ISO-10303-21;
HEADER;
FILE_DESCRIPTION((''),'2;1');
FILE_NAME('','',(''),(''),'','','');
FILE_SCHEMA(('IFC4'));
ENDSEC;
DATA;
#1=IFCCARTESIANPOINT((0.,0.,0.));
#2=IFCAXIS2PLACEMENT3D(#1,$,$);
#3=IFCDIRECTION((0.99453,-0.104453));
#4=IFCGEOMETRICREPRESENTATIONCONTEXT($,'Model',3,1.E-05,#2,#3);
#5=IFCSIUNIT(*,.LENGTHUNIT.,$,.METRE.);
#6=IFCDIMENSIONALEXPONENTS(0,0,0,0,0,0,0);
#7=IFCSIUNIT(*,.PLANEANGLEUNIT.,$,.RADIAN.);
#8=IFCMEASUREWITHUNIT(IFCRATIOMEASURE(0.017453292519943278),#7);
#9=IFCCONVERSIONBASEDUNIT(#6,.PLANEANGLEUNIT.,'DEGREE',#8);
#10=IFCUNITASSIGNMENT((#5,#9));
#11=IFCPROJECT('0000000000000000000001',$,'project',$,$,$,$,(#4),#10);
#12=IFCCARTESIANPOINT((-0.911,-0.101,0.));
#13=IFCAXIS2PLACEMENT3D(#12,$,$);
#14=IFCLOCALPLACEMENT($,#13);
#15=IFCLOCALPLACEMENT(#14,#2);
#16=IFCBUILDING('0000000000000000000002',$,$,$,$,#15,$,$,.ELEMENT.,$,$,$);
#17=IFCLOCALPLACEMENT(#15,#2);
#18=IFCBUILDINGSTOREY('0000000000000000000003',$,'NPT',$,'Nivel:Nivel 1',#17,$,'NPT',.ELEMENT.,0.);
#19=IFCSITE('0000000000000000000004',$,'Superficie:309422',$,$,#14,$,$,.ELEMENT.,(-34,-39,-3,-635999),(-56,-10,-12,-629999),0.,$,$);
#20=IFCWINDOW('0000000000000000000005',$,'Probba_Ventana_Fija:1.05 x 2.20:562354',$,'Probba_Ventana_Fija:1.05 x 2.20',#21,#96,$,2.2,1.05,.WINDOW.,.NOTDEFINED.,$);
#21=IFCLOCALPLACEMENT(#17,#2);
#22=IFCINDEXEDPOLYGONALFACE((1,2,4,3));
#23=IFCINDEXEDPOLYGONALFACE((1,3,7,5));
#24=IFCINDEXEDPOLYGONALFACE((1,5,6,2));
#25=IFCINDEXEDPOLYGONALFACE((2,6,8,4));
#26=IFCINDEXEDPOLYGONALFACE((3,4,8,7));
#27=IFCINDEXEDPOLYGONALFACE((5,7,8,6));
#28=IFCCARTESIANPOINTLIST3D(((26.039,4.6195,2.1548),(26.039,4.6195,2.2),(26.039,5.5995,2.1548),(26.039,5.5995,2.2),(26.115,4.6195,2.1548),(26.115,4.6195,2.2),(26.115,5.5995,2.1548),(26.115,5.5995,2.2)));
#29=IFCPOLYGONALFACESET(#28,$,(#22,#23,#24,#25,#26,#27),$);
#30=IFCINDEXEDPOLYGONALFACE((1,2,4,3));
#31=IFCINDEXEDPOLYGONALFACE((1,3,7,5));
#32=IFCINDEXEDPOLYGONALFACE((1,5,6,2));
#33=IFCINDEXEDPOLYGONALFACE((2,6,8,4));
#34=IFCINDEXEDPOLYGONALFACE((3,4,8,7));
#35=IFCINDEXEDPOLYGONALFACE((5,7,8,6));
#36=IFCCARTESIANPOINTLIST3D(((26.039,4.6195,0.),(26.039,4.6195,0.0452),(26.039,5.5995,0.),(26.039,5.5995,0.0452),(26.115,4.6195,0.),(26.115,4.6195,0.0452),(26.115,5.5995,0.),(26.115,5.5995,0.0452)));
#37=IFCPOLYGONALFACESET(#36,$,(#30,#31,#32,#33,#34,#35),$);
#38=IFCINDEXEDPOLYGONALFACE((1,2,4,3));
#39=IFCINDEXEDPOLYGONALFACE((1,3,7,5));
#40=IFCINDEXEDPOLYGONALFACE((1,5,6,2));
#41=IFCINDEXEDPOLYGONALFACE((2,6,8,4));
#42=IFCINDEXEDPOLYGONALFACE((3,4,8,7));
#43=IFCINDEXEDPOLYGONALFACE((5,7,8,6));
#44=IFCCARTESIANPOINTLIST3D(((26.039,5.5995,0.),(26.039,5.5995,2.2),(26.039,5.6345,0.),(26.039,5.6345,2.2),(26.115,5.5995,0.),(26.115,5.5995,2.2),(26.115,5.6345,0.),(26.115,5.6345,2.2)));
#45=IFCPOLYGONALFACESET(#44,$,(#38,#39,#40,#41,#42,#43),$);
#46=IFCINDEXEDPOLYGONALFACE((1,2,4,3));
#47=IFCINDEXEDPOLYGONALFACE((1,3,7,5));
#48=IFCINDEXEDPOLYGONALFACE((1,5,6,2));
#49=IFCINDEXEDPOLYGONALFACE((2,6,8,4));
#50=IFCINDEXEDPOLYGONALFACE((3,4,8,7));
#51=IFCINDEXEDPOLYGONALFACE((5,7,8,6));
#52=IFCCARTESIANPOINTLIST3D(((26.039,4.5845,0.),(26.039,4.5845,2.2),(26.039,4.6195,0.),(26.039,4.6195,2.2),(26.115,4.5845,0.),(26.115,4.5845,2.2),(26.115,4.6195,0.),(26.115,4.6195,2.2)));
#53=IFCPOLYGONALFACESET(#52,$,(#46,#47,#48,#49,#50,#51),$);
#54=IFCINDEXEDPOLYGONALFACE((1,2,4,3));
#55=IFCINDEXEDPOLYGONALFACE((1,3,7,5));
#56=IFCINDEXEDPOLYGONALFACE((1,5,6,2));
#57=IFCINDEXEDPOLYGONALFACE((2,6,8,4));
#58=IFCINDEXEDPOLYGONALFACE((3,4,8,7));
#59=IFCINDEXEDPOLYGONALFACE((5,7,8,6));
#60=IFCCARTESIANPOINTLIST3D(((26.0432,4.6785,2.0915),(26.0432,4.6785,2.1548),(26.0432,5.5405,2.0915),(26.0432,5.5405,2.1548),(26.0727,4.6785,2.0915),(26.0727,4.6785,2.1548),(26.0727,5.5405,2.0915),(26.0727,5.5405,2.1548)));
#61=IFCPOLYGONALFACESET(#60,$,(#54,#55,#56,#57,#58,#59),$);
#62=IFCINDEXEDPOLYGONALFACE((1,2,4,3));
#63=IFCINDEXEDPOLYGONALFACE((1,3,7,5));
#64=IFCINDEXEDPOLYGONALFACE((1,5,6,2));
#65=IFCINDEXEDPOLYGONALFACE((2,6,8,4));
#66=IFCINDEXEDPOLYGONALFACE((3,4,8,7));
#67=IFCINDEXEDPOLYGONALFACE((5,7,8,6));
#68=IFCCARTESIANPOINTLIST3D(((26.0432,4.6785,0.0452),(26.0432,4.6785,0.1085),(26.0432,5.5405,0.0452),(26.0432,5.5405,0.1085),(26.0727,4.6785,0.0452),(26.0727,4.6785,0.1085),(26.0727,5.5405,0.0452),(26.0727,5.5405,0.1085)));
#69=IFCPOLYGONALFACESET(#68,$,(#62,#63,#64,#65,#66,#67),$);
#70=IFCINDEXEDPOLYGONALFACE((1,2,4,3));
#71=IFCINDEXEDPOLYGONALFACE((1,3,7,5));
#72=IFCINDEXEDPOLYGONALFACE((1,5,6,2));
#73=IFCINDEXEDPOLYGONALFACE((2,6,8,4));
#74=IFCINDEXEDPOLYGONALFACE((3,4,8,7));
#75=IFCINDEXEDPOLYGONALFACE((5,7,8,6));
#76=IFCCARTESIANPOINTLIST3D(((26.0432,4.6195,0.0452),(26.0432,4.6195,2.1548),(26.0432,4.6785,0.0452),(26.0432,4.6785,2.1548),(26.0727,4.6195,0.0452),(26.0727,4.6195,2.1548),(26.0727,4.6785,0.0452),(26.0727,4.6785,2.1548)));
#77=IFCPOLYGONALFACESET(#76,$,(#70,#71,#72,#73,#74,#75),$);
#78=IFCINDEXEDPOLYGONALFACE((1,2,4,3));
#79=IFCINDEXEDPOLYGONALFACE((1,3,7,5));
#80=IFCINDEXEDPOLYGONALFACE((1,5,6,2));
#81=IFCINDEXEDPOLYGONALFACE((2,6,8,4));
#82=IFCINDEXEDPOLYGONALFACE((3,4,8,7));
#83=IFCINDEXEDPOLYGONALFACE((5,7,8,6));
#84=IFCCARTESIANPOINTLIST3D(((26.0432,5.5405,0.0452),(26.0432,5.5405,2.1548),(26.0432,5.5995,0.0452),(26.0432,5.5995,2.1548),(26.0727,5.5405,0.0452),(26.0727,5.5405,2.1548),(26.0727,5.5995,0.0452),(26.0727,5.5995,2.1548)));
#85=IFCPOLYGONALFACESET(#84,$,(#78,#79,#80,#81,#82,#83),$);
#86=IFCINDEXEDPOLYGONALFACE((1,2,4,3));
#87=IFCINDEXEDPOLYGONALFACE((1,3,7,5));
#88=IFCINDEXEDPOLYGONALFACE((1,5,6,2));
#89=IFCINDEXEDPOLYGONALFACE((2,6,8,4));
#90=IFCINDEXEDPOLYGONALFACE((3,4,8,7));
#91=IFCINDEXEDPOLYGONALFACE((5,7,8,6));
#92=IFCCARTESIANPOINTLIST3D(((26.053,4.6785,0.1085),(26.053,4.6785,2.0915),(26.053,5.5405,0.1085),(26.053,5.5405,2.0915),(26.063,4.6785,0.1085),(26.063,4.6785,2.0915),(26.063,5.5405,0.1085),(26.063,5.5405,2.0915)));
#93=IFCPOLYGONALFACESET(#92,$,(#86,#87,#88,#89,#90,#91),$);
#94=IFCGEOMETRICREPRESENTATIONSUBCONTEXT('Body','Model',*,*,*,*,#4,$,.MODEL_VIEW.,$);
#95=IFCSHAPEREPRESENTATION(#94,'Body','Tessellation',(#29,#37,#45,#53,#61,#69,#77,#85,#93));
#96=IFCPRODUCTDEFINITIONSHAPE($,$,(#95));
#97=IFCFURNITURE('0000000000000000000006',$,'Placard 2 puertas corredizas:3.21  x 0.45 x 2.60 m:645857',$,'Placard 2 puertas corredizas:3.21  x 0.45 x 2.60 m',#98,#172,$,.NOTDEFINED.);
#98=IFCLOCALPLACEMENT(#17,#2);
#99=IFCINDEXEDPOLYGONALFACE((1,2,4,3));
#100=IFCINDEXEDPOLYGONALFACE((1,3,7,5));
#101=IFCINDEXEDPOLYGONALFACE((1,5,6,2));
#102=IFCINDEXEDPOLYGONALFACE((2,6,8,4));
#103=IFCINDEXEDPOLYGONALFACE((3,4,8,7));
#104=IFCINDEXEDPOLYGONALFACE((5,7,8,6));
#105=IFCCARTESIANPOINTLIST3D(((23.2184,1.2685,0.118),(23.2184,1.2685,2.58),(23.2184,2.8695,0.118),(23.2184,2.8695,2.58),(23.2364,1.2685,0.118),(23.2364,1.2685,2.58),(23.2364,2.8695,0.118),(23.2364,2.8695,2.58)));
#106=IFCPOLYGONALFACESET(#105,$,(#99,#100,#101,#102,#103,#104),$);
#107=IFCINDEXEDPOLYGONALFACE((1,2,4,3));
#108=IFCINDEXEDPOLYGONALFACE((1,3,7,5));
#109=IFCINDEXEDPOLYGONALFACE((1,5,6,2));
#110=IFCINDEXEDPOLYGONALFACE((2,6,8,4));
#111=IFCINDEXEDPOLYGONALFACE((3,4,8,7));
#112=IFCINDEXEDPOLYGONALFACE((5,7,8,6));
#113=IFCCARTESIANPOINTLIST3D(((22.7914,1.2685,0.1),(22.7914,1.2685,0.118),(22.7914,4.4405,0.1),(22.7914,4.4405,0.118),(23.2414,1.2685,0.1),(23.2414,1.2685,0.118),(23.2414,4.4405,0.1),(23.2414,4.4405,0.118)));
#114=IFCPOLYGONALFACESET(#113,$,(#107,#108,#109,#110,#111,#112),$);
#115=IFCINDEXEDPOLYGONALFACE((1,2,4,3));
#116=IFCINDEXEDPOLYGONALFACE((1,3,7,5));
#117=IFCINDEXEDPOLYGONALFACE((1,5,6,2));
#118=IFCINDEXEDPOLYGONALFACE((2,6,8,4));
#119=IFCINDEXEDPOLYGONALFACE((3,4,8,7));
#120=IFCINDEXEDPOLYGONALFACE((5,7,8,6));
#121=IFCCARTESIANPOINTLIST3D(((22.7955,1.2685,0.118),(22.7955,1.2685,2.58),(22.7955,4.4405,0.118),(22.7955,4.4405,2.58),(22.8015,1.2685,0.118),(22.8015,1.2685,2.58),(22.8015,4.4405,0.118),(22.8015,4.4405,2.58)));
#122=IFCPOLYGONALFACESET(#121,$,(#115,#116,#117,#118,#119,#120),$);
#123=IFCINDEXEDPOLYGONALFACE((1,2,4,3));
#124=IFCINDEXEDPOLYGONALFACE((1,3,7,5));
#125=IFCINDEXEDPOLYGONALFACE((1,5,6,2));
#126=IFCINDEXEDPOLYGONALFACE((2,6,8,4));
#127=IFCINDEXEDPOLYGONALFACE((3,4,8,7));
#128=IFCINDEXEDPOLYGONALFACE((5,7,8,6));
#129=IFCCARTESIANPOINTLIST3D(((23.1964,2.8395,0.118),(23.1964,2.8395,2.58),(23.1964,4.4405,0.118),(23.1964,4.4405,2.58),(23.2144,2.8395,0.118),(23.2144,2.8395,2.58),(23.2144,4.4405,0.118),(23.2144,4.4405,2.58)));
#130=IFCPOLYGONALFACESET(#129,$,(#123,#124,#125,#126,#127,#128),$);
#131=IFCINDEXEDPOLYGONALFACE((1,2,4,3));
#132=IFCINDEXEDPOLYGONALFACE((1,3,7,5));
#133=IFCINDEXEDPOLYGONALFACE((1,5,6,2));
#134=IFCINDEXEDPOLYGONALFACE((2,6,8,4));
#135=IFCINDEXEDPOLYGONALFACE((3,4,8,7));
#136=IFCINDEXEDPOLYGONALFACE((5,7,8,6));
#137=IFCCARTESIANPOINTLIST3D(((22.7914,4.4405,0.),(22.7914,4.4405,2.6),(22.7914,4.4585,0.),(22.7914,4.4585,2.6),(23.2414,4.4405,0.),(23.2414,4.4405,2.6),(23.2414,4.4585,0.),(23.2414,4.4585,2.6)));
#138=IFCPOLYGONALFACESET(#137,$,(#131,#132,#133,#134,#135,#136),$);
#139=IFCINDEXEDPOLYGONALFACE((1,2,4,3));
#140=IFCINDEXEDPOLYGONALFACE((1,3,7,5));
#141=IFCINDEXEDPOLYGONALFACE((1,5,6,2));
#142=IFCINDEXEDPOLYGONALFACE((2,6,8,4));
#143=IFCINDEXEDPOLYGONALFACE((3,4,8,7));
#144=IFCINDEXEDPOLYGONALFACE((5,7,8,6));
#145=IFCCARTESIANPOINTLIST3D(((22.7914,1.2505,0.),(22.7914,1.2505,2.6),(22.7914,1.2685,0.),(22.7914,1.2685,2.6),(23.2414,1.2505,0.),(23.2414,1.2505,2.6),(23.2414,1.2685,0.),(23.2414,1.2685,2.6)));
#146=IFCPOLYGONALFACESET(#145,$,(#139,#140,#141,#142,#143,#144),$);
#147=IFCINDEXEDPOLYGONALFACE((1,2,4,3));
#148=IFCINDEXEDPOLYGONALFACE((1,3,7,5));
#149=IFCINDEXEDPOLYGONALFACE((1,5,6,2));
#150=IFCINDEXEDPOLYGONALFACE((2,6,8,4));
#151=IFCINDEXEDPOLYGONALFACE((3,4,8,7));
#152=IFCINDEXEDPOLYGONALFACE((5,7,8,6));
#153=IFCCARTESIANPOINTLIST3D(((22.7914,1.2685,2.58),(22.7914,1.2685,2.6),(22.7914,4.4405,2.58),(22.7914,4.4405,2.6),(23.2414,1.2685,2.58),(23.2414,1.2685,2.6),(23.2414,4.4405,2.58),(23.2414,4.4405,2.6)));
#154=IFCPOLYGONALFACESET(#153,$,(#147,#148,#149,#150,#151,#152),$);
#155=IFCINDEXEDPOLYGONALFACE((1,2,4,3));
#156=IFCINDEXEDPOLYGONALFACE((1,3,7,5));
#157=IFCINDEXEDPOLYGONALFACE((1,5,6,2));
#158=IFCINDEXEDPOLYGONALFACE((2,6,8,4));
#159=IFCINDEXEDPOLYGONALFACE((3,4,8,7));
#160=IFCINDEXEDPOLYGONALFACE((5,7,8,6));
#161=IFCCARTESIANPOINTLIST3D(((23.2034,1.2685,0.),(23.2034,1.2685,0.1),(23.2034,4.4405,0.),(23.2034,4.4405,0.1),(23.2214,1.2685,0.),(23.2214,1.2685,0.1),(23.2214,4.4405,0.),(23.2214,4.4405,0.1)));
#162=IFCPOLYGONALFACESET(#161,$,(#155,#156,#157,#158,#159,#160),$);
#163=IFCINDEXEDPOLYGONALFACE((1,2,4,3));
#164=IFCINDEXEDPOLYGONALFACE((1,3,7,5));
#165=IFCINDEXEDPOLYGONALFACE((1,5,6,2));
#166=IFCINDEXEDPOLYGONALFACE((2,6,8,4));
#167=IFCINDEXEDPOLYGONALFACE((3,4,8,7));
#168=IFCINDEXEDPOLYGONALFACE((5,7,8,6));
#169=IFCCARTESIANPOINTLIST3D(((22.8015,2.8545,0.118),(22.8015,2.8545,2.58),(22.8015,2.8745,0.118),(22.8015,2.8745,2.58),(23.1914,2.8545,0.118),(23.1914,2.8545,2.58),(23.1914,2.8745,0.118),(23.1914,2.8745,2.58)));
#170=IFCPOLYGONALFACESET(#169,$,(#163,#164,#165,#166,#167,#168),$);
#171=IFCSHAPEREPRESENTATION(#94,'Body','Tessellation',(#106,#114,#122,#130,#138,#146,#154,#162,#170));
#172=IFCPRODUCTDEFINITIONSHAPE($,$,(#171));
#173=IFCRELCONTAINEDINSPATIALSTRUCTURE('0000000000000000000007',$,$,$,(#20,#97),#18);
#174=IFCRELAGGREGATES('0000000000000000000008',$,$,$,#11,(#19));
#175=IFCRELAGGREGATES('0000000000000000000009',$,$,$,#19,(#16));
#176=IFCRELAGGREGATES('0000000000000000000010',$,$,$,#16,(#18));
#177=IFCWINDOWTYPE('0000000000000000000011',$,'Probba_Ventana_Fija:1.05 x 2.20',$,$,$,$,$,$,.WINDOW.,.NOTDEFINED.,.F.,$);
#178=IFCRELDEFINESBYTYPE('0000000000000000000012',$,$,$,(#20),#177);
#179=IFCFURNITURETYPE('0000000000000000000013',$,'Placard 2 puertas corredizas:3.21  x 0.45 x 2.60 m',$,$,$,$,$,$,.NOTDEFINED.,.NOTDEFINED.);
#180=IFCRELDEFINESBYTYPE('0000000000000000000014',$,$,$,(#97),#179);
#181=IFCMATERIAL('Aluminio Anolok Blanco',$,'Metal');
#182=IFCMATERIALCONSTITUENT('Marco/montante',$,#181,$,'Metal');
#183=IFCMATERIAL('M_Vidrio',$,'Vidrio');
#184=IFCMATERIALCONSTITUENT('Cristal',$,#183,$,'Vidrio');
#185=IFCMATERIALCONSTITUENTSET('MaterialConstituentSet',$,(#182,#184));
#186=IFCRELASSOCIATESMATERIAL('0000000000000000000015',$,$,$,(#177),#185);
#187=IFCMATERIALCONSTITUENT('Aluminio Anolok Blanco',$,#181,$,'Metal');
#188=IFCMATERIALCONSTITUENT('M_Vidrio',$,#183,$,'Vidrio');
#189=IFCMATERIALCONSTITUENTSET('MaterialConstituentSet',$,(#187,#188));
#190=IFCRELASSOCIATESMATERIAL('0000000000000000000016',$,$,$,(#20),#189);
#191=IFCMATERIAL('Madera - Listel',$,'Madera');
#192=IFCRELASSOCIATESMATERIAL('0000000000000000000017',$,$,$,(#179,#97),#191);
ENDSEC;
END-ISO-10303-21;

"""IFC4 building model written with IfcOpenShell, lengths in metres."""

from ifc_helpers import new_model, entity, si_unit, converted_unit, direction, frame, frame_2d, origin, origin_2d_with_axis, place, context, subcontext, project, spatial, rectangle, extrude, source, transform, mapped, material, constituent, constituent_set, type_object, type_shapes, element, save


model = new_model("IFC4")

# Units and contexts
model_context = context("Model", 3, precision=1e-05, world=origin(), true_north=direction((0.99453, -0.104453)))
body_context = subcontext(model_context, "Body", "Model", "MODEL_VIEW")
ifc_project = project(units=[si_unit("LENGTHUNIT", "METRE"), converted_unit("PLANEANGLEUNIT", "DEGREE", entity("IfcRatioMeasure", 0.017453292519943278), si_unit("PLANEANGLEUNIT", "RADIAN"), dimensions=[0, 0, 0, 0, 0, 0, 0])], contexts=[model_context])

# Site, building, storey
site_placement = place(None, frame((-0.911, -0.101, 0.0)))
site = spatial("IfcSite", under=ifc_project, at=site_placement, Name="Superficie:309422", CompositionType="ELEMENT", RefLatitude=(-34, -39, -3, -635999), RefLongitude=(-56, -10, -12, -629999), RefElevation=0.0)
building_placement = place(site_placement, origin())
building = spatial("IfcBuilding", under=site, at=building_placement, CompositionType="ELEMENT")
storey_placement = place(building_placement, origin())
storey = spatial("IfcBuildingStorey", under=building, at=storey_placement, Name="NPT", ObjectType="Nivel:Nivel 1", LongName="NPT", CompositionType="ELEMENT", Elevation=0.0)

# Window
ifc_material_1 = material(Name="Aluminio Anolok Blanco", Category="Metal")
ifc_constituent_1 = constituent(ifc_material_1, Name="Aluminio Anolok Blanco", Category="Metal")
ifc_material_2 = material(Name="M_Vidrio", Category="Vidrio")
ifc_constituent_2 = constituent(ifc_material_2, Name="M_Vidrio", Category="Vidrio")
ifc_constituent_set_1 = constituent_set(constituents=[ifc_constituent_1, ifc_constituent_2], Name="MaterialConstituentSet")
ifc_constituent_3 = constituent(ifc_material_1, Name="Marco/montante", Category="Metal")
ifc_constituent_4 = constituent(ifc_material_2, Name="Cristal", Category="Vidrio")
ifc_constituent_set_2 = constituent_set(constituents=[ifc_constituent_3, ifc_constituent_4], Name="MaterialConstituentSet")
window_type = type_object("IfcWindowType", Name="Probba_Ventana_Fija:1.05 x 2.20", ParameterTakesPrecedence=False, PartitioningType="NOTDEFINED", PredefinedType="WINDOW", material=ifc_constituent_set_2)
shared_shape_1 = source(origin(), body_context, "Body", "SweptSolid", [
    extrude(rectangle(XDim=0.98, YDim=0.076, at=origin_2d_with_axis()), frame((0.525, 0.038, 2.1548)), (0.0, 0.0, 1.0), 0.0452),
    extrude(rectangle(XDim=0.98, YDim=0.076, at=frame_2d((0.0, 0.0), x_axis=(1.0, 0.0))), frame((0.525, 0.038, 0.0)), (0.0, 0.0, 1.0), 0.0452),
    extrude(rectangle(XDim=0.035, YDim=0.076, at=frame_2d((0.0, 0.0), x_axis=(1.0, 0.0))), frame((0.0175, 0.038, 0.0), z_axis=(0.0, 0.0, 1.0), x_axis=(-1.0, 0.0, 0.0)), (0.0, 0.0, 1.0), 2.2),
    extrude(rectangle(XDim=0.035, YDim=0.076, at=origin_2d_with_axis()), frame((1.0325, 0.038, 0.0), z_axis=(0.0, 0.0, 1.0), x_axis=(-1.0, 0.0, 0.0)), (0.0, 0.0, 1.0), 2.2),
    extrude(rectangle(XDim=0.862, YDim=0.0295, at=frame_2d((0.0, 0.0), x_axis=(1.0, 0.0))), frame((0.525, 0.019, 2.0915)), (0.0, 0.0, 1.0), 0.0633),
    extrude(rectangle(XDim=0.862, YDim=0.0295, at=origin_2d_with_axis()), frame((0.525, 0.019, 0.0452)), (0.0, 0.0, 1.0), 0.0633),
    extrude(rectangle(XDim=0.0295, YDim=0.059, at=origin_2d_with_axis()), frame((0.9855, 0.019, 0.0452), z_axis=(0.0, 0.0, 1.0), x_axis=(0.0, 1.0, 0.0)), (0.0, 0.0, 1.0), 2.1096),
    extrude(rectangle(XDim=0.0295, YDim=0.059, at=origin_2d_with_axis()), frame((0.0645, 0.019, 0.0452), z_axis=(0.0, 0.0, 1.0), x_axis=(0.0, 1.0, 0.0)), (0.0, 0.0, 1.0), 2.1096),
    extrude(rectangle(XDim=0.01, YDim=0.862, at=frame_2d((0.0, 0.0), x_axis=(1.0, 0.0))), frame((0.525, 0.019, 0.1085), z_axis=(0.0, 0.0, 1.0), x_axis=(0.0, 1.0, 0.0)), (0.0, 0.0, 1.0), 1.983),
])
type_shapes(window_type, [shared_shape_1])
window_placement = place(storey_placement, frame((26.039, 5.6345, 0.0), z_axis=(0.0, 0.0, 1.0), x_axis=(0.0, -1.0, 0.0)))
element("IfcWindow", 1, at=window_placement, inside=storey, type_object=window_type, material=ifc_constituent_set_1, Name="Probba_Ventana_Fija:1.05 x 2.20:562354", ObjectType="Probba_Ventana_Fija:1.05 x 2.20", OverallHeight=2.2, OverallWidth=1.05, PartitioningType="NOTDEFINED", PredefinedType="WINDOW", context=body_context, shape_type="MappedRepresentation", body=[
    mapped(shared_shape_1, transform((0.0, 0.0, 0.0), scale=1.0)),
])

# Furniture
ifc_material_3 = material(Name="Madera - Listel", Category="Madera")
furniture_type_1 = type_object("IfcFurnitureType", Name="Placard 2 puertas corredizas:3.21  x 0.45 x 2.60 m", AssemblyPlace="NOTDEFINED", PredefinedType="NOTDEFINED", material=ifc_material_3)
shared_shape_2 = source(origin(), body_context, "Body", "SweptSolid", [
    extrude(rectangle(XDim=0.018, YDim=1.601, at=frame_2d((0.0, 0.0), x_axis=(1.0, 0.0))), frame((-0.7855, -0.161, 0.118), z_axis=(0.0, 0.0, 1.0), x_axis=(0.0, 1.0, 0.0)), (0.0, 0.0, 1.0), 2.462),
    extrude(rectangle(XDim=0.45, YDim=3.172, at=origin_2d_with_axis()), frame((0.0, 0.05, 0.1), z_axis=(0.0, 0.0, 1.0), x_axis=(0.0, 1.0, 0.0)), (0.0, 0.0, 1.0), 0.018),
    extrude(rectangle(XDim=3.172, YDim=0.006, at=frame_2d((0.0, 0.0), x_axis=(1.0, 0.0))), frame((0.0, 0.2679, 0.118), z_axis=(0.0, 0.0, 1.0), x_axis=(-1.0, 0.0, 0.0)), (0.0, 0.0, 1.0), 2.462),
    extrude(rectangle(XDim=0.018, YDim=1.601, at=origin_2d_with_axis()), frame((0.7855, -0.139, 0.118), z_axis=(0.0, 0.0, 1.0), x_axis=(0.0, 1.0, 0.0)), (0.0, 0.0, 1.0), 2.462),
    extrude(rectangle(XDim=0.45, YDim=0.018, at=frame_2d((0.0, 0.0), x_axis=(1.0, 0.0))), frame((1.595, 0.05, 0.0), z_axis=(0.0, 0.0, 1.0), x_axis=(0.0, -1.0, 0.0)), (0.0, 0.0, 1.0), 2.6),
    extrude(rectangle(XDim=0.018, YDim=0.45, at=frame_2d((0.0, 0.0), x_axis=(1.0, 0.0))), frame((-1.595, 0.05, 0.0), z_axis=(0.0, 0.0, 1.0), x_axis=(-1.0, 0.0, 0.0)), (0.0, 0.0, 1.0), 2.6),
    extrude(rectangle(XDim=0.45, YDim=3.172, at=origin_2d_with_axis()), frame((0.0, 0.05, 2.58), z_axis=(0.0, 0.0, 1.0), x_axis=(0.0, 1.0, 0.0)), (0.0, 0.0, 1.0), 0.02),
    extrude(rectangle(XDim=0.018, YDim=3.172, at=origin_2d_with_axis()), frame((0.0, -0.146, 0.0), z_axis=(0.0, 0.0, 1.0), x_axis=(0.0, 1.0, 0.0)), (0.0, 0.0, 1.0), 0.1),
    extrude(rectangle(XDim=0.02, YDim=0.3899, at=frame_2d((0.0, 0.0), x_axis=(1.0, 0.0))), frame((0.01, 0.0699, 0.118), z_axis=(0.0, 0.0, 1.0), x_axis=(-1.0, 0.0, 0.0)), (0.0, 0.0, 1.0), 2.462),
])
type_shapes(furniture_type_1, [shared_shape_2])
furniture_1_placement = place(storey_placement, frame((23.0664, 2.8545, 0.0), z_axis=(0.0, 0.0, 1.0), x_axis=(0.0, 1.0, 0.0)))
element("IfcFurniture", 2, at=furniture_1_placement, inside=storey, type_object=furniture_type_1, material=ifc_material_3, Name="Placard 2 puertas corredizas:3.21  x 0.45 x 2.60 m:645857", ObjectType="Placard 2 puertas corredizas:3.21  x 0.45 x 2.60 m", PredefinedType="NOTDEFINED", context=body_context, shape_type="MappedRepresentation", body=[
    mapped(shared_shape_2, transform((0.0, 0.0, 0.0), scale=1.0)),
])

save(model, "model.ifc")
